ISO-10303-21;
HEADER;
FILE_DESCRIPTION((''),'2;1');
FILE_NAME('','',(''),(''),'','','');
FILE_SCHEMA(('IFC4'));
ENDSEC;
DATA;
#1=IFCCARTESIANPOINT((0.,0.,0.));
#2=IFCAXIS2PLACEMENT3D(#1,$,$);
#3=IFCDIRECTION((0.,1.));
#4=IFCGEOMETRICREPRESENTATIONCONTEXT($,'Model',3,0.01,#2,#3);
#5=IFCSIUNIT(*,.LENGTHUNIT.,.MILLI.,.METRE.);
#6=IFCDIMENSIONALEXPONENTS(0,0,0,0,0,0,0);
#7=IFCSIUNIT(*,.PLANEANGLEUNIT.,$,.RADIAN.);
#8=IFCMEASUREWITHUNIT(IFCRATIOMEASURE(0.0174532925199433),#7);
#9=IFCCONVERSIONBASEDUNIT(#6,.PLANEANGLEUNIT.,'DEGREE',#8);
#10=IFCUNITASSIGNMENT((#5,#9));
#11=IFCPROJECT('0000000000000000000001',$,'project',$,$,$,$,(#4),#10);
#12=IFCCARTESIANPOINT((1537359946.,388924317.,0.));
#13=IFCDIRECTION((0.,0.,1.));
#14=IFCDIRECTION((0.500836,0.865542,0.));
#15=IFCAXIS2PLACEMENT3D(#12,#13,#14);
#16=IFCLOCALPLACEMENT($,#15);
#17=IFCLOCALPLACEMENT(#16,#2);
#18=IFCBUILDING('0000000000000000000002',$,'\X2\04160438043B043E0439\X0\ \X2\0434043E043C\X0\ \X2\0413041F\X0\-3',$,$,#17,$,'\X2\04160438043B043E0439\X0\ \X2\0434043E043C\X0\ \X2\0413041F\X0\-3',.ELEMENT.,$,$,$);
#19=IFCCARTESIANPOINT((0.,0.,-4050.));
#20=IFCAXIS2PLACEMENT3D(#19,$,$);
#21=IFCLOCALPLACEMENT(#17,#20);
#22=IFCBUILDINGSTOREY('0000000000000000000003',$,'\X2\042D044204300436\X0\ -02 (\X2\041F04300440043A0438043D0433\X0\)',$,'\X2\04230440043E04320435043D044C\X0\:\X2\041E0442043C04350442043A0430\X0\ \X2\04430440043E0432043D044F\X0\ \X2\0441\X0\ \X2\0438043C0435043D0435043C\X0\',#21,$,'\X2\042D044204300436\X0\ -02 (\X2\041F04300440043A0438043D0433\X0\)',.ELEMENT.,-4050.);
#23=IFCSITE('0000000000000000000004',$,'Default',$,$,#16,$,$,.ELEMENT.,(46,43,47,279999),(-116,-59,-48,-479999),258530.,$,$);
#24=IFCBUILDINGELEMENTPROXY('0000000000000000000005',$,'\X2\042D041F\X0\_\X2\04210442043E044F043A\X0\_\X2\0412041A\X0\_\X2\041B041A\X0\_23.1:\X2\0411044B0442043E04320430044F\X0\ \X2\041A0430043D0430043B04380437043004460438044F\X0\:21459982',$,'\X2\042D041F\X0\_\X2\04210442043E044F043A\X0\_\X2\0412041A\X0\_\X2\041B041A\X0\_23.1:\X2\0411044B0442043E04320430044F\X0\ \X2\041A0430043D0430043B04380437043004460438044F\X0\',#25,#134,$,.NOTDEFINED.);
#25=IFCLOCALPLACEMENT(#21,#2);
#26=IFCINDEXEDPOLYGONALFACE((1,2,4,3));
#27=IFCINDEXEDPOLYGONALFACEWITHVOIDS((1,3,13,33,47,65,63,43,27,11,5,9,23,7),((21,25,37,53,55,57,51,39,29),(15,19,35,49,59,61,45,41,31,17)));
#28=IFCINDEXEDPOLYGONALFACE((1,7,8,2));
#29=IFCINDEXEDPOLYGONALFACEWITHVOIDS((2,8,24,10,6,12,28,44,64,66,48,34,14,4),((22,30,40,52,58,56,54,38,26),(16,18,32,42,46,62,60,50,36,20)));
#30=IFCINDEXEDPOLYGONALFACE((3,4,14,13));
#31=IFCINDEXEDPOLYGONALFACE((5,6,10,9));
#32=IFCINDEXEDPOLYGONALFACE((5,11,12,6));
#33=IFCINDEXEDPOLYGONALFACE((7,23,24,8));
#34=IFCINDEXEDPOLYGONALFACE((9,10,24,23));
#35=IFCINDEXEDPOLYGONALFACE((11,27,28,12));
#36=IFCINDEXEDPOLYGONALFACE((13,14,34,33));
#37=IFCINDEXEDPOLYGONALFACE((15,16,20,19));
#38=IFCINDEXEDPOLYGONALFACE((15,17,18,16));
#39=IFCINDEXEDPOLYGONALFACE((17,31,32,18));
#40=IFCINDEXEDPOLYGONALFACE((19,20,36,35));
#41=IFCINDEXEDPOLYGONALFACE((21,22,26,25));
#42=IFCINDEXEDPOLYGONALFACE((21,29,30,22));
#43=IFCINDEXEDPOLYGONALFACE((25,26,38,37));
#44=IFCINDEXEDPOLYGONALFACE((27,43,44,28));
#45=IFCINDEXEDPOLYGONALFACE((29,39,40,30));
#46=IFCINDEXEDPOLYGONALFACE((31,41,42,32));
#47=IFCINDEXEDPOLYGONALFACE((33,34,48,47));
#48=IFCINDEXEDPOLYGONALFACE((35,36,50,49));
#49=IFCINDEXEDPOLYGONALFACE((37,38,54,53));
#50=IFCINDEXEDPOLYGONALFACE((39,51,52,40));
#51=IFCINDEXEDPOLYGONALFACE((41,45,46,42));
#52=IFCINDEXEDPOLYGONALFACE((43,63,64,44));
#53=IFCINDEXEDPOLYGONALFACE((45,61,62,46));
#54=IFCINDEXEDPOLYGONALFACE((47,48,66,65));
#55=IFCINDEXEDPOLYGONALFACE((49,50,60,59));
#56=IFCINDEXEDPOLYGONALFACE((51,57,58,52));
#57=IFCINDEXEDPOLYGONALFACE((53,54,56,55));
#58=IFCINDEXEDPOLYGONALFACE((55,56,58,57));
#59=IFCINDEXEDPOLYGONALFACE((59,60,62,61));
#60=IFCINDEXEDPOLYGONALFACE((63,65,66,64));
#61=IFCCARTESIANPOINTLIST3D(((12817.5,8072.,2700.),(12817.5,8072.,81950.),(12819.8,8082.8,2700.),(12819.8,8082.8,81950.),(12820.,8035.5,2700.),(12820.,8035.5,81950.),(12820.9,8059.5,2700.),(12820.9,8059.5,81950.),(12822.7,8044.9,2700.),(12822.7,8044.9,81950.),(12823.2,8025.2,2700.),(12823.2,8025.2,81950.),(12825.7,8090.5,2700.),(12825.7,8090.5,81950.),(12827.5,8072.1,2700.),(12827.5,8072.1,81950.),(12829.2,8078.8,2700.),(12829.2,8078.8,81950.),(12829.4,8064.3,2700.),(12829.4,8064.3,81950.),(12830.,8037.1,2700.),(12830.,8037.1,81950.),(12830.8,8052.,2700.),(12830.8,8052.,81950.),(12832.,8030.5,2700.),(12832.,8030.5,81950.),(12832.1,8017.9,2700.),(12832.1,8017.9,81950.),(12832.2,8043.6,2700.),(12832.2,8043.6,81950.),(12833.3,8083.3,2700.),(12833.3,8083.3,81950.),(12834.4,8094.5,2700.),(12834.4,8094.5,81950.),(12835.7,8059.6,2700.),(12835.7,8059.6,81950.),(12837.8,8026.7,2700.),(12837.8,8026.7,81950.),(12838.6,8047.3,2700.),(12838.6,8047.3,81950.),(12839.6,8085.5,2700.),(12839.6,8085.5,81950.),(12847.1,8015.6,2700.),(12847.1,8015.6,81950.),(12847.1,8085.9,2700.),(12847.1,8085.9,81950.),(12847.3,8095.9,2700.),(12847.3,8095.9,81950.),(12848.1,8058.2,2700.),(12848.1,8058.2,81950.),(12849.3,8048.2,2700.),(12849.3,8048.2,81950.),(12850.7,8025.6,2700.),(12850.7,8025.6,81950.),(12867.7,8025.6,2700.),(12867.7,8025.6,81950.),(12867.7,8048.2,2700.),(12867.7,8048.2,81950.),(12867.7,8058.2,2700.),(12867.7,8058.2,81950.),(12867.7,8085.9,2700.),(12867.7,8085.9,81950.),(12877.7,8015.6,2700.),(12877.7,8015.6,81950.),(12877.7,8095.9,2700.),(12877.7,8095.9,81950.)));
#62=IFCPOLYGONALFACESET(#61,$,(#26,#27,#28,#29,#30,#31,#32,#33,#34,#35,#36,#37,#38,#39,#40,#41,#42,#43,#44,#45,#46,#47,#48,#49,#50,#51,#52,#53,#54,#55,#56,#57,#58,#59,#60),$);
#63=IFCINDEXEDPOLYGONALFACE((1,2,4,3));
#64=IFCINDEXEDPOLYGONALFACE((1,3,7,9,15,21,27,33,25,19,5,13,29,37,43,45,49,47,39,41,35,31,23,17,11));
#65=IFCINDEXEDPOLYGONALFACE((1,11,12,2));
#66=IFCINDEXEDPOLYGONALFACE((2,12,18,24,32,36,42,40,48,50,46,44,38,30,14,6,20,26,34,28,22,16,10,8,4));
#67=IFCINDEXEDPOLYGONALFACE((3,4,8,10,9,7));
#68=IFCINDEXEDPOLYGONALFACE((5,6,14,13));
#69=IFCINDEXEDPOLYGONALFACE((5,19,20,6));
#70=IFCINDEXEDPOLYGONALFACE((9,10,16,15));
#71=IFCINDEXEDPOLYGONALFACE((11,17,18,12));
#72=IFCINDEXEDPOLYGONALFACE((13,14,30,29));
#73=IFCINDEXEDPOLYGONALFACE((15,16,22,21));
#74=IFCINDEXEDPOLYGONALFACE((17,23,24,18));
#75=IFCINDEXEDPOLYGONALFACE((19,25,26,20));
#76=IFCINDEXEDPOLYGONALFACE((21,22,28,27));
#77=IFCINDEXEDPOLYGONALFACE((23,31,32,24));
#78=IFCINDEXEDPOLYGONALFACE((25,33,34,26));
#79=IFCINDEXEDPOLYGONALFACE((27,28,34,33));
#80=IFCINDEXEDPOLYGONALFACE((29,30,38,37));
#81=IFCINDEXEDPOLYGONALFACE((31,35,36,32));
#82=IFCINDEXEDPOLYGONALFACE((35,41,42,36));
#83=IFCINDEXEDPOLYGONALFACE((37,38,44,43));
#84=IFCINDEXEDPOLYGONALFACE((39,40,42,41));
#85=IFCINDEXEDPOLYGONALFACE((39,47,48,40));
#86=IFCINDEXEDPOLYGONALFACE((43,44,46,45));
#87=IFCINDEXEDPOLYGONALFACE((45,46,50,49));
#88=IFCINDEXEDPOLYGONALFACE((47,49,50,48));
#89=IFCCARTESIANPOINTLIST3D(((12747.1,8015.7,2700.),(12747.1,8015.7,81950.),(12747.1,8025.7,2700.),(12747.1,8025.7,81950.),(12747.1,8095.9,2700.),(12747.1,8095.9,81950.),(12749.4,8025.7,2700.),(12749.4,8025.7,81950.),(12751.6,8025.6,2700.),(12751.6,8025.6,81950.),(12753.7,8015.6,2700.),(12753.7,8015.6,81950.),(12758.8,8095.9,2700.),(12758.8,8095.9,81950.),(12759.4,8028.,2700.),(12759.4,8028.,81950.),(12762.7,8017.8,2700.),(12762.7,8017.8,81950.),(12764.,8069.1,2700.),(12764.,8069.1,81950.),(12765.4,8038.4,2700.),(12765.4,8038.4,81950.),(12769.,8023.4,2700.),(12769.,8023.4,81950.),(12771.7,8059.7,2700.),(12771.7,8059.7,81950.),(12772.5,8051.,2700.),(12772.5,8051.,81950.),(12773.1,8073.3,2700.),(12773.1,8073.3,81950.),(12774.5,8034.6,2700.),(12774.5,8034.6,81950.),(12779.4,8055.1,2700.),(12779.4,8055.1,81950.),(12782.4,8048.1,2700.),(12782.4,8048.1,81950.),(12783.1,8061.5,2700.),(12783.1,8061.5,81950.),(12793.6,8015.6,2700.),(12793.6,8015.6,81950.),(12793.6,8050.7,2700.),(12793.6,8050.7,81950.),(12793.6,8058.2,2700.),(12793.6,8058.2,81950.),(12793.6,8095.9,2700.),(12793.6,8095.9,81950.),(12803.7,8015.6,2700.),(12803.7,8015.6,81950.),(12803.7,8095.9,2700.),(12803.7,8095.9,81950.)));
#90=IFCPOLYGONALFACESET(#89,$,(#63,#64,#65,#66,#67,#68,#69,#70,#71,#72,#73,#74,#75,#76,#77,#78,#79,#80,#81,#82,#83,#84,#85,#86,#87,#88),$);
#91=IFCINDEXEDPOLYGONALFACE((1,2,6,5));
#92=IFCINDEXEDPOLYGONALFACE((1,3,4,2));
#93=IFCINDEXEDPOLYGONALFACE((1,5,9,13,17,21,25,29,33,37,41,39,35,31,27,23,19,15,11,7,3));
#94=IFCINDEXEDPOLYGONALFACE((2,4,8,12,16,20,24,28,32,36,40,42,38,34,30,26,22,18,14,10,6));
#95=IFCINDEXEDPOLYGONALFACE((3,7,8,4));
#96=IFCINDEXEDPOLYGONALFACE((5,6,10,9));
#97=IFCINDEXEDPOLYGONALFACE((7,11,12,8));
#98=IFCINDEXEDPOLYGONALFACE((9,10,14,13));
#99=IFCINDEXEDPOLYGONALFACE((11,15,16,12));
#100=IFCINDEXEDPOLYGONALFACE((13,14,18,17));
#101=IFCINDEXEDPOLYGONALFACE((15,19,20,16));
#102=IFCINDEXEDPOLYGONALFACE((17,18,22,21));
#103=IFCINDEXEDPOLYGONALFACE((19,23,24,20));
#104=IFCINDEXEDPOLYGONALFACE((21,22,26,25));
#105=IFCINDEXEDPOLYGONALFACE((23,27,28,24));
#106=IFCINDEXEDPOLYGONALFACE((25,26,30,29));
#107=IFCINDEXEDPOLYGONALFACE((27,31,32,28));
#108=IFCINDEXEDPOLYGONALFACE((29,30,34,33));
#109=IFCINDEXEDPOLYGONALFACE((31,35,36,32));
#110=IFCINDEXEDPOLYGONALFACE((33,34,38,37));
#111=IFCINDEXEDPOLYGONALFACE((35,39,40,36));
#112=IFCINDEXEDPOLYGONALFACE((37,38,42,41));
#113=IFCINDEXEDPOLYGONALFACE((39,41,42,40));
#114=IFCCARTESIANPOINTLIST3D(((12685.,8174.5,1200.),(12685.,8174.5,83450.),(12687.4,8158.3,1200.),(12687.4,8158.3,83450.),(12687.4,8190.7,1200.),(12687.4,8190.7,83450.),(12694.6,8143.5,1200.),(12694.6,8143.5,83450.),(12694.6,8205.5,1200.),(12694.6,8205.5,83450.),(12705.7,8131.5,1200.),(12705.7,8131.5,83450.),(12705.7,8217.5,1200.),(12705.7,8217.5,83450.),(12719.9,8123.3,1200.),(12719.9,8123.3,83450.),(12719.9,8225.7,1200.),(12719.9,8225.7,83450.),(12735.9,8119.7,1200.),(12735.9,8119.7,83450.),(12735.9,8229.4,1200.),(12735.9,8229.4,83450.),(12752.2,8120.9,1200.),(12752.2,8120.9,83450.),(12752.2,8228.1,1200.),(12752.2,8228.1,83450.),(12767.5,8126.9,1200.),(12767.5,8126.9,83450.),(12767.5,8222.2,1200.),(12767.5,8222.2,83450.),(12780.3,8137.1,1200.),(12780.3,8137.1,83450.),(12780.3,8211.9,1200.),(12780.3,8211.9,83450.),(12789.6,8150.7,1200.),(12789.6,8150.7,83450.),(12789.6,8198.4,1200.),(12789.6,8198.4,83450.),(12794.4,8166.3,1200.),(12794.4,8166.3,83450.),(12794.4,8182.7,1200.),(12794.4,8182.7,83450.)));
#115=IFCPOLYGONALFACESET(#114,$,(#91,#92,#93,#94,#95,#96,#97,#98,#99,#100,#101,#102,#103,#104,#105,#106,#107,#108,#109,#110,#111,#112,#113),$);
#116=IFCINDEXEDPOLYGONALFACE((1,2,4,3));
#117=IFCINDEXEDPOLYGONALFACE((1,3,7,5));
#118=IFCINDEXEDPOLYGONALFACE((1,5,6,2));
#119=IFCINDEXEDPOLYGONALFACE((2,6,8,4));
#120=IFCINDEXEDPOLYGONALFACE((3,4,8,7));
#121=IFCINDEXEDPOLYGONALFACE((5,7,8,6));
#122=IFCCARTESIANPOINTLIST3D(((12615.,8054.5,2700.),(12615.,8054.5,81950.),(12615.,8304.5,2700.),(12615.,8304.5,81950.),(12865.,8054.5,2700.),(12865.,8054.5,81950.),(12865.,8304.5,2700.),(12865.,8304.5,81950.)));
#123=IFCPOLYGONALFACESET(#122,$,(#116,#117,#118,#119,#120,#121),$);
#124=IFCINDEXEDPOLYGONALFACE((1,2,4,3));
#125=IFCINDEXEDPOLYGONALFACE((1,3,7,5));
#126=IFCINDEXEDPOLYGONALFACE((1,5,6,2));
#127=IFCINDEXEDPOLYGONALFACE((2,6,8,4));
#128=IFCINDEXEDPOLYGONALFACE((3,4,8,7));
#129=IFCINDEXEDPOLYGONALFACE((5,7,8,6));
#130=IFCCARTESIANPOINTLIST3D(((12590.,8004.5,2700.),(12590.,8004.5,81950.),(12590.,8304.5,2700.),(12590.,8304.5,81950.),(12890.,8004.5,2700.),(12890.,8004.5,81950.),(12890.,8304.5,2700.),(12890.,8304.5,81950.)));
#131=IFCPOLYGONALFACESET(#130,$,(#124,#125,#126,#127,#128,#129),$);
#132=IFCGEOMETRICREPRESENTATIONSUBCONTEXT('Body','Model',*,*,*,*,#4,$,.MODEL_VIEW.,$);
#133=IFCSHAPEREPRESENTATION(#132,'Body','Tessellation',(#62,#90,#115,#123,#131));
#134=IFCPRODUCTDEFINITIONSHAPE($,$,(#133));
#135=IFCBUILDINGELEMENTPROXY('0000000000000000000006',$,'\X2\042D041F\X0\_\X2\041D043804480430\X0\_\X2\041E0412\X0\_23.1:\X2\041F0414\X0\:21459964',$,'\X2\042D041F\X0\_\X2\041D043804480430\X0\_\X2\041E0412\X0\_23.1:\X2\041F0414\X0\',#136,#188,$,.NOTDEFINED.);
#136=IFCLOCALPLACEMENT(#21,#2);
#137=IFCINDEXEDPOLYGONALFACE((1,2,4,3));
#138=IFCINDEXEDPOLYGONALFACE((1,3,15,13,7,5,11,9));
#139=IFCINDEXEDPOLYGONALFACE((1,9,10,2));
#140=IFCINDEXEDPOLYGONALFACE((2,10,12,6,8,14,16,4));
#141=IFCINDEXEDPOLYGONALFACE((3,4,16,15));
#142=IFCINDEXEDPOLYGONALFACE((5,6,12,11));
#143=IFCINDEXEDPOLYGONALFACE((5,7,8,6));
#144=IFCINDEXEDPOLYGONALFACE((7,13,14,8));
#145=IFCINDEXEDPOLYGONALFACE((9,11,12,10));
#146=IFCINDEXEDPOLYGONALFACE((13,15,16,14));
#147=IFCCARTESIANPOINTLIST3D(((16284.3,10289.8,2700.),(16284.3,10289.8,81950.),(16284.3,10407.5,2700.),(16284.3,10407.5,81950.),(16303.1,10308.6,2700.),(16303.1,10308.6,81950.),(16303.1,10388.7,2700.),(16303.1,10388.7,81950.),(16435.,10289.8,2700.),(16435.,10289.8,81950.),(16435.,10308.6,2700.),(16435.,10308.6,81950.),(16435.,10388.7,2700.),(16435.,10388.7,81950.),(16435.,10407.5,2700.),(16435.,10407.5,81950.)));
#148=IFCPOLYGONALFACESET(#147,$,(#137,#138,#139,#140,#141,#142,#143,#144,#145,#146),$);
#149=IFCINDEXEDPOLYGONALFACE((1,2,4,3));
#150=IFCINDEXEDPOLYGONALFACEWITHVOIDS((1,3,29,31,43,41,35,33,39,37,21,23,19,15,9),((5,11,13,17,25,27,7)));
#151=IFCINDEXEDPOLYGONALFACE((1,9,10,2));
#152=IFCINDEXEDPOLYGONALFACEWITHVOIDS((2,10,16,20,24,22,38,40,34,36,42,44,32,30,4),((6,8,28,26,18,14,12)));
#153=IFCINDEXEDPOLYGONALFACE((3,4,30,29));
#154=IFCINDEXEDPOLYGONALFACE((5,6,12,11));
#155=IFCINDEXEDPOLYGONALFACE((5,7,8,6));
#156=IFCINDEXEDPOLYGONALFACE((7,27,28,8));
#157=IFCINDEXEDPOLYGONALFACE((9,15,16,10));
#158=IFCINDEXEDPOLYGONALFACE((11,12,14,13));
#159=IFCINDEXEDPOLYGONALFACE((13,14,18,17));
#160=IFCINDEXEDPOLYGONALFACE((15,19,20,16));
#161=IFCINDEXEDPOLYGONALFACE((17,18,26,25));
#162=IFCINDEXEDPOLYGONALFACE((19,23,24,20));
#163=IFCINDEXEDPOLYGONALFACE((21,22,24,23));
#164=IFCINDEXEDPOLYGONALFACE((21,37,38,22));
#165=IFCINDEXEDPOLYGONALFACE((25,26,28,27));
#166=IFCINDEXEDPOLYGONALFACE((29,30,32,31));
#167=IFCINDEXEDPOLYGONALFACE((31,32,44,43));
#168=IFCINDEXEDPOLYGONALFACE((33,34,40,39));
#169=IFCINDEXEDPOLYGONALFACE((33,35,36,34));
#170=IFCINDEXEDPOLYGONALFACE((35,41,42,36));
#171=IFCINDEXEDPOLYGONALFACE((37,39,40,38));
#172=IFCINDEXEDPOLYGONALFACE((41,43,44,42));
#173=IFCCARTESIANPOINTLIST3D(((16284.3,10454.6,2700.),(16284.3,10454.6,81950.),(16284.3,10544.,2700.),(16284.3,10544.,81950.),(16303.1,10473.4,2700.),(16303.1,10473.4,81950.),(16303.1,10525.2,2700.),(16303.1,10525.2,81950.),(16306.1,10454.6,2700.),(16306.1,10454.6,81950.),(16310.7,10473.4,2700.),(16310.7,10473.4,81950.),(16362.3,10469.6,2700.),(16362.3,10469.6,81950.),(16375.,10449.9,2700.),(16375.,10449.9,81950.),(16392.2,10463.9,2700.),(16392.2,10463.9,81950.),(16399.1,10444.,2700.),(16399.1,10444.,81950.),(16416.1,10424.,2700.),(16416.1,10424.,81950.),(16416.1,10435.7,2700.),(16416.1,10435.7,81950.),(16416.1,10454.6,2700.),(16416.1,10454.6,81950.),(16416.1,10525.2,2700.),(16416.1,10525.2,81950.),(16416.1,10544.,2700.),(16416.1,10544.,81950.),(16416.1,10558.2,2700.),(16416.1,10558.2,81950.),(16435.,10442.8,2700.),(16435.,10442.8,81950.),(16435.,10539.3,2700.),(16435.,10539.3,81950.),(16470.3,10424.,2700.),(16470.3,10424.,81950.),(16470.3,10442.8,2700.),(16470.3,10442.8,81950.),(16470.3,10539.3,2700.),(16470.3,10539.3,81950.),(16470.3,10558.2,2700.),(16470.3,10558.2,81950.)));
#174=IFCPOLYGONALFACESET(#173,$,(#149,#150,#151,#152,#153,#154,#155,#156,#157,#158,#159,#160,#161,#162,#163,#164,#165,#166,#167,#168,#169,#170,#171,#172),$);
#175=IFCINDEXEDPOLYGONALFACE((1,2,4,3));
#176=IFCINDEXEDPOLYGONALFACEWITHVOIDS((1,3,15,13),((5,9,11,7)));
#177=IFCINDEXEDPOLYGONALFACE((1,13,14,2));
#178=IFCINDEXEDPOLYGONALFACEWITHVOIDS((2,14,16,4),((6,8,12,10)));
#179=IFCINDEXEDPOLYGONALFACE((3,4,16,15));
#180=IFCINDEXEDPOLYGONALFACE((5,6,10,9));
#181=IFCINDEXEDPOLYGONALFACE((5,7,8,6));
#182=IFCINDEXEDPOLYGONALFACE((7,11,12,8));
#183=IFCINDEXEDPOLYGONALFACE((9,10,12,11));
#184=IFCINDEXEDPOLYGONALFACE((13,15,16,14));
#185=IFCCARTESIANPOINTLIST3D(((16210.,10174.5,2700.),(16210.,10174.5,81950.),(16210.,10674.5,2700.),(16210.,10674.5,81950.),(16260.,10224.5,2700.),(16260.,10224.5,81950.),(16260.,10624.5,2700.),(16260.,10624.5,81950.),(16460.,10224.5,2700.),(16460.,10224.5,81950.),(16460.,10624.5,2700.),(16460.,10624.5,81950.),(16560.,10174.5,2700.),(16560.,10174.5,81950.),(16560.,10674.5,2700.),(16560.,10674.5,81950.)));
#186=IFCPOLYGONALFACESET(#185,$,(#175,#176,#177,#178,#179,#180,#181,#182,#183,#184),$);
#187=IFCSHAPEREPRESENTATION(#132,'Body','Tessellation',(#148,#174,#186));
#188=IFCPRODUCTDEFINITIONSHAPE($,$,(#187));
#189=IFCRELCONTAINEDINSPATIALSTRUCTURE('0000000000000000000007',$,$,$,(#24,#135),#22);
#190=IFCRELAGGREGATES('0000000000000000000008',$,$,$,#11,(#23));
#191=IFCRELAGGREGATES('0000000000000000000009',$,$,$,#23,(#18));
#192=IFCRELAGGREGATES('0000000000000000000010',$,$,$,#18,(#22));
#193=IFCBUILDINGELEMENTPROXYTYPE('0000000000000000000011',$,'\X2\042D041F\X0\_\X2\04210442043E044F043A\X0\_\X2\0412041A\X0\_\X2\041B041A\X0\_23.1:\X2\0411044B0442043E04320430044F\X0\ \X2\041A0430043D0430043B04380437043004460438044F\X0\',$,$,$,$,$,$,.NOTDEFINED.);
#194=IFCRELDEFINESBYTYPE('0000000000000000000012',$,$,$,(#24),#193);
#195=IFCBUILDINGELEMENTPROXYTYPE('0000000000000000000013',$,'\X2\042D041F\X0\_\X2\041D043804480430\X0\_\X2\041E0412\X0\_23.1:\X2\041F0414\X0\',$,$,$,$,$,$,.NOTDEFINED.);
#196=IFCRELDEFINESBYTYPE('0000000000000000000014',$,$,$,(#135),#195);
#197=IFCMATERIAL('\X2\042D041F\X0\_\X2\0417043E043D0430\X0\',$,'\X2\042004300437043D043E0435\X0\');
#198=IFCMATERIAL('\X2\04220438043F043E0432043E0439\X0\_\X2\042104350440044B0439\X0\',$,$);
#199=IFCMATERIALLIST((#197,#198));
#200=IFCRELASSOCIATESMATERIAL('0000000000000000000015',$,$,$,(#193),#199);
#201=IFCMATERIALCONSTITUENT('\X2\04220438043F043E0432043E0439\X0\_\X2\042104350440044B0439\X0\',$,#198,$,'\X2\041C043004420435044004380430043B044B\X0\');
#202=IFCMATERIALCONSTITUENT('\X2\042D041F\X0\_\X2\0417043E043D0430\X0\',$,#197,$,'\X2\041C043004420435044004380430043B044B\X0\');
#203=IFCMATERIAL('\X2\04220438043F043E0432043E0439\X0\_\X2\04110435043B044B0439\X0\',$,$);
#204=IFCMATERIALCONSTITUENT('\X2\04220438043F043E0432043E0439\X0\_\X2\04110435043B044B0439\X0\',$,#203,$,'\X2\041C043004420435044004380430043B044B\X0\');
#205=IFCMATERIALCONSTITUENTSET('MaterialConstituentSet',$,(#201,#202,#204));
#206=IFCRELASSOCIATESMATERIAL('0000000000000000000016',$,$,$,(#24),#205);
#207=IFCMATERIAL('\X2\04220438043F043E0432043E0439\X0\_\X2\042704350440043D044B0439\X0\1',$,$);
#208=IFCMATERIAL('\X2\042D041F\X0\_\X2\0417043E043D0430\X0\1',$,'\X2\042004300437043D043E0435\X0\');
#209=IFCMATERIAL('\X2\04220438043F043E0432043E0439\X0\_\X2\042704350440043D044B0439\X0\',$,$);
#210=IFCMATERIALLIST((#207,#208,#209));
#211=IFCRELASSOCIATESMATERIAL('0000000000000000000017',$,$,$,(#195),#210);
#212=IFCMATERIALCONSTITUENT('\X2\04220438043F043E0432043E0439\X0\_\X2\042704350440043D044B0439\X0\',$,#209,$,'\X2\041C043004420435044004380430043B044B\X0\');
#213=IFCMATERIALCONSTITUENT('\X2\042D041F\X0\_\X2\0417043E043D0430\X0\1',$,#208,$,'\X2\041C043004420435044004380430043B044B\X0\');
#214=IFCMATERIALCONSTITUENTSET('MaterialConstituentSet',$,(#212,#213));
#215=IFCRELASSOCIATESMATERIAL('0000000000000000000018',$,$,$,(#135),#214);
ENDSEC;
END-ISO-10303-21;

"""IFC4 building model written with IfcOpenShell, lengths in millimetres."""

from ifc_helpers import new_model, entity, si_unit, converted_unit, direction, frame, frame_2d, origin, place, context, subcontext, project, spatial, polyline, rectangle, circle, outline, extrude, source, transform, mapped, material, material_list, constituent, constituent_set, type_object, type_shapes, element, save


model = new_model("IFC4")

# Units and contexts
model_context = context("Model", 3, precision=0.01, world=origin(), true_north=direction((0.0, 1.0)))
body_context = subcontext(model_context, "Body", "Model", "MODEL_VIEW")
ifc_project = project(units=[si_unit("LENGTHUNIT", "METRE", prefix="MILLI"), converted_unit("PLANEANGLEUNIT", "DEGREE", entity("IfcRatioMeasure", 0.0174532925199433), si_unit("PLANEANGLEUNIT", "RADIAN"), dimensions=[0, 0, 0, 0, 0, 0, 0])], contexts=[model_context])

# Site, building, storey
site_placement = place(None, frame((1537359946.0, 388924317.0, 0.0), z_axis=(0.0, 0.0, 1.0), x_axis=(0.500836, 0.865542, 0.0)))
site = spatial("IfcSite", under=ifc_project, at=site_placement, Name="Default", CompositionType="ELEMENT", RefLatitude=(46, 43, 47, 279999), RefLongitude=(-116, -59, -48, -479999), RefElevation=258530.0)
building_placement = place(site_placement, origin())
building = spatial("IfcBuilding", under=site, at=building_placement, Name="Жилой дом ГП-3", LongName="Жилой дом ГП-3", CompositionType="ELEMENT")
storey_placement = place(building_placement, frame((0.0, 0.0, -4050.0)))
storey = spatial("IfcBuildingStorey", under=building, at=storey_placement, Name="Этаж -02 (Паркинг)", ObjectType="Уровень:Отметка уровня с именем", LongName="Этаж -02 (Паркинг)", CompositionType="ELEMENT", Elevation=-4050.0)

# Building element proxies
ifc_material_1 = material(Name="Типовой_Серый")
ifc_material_2 = material(Name="ЭП_Зона", Category="Разное")
ifc_material_3 = material(Name="Типовой_Белый")
ifc_material_list_1 = material_list([ifc_material_2, ifc_material_1])
building_element_proxy_type_1 = type_object("IfcBuildingElementProxyType", Name="ЭП_Стояк_ВК_ЛК_23.1:Бытовая Канализация", PredefinedType="NOTDEFINED", material=ifc_material_list_1)
shared_shape_1 = source(origin(), body_context, "Body", "SweptSolid", [
    extrude(outline(polyline([(-42.2, -39.0), (-11.8, -39.0), (1.1, -37.6), (9.8, -33.5), (15.7, -25.8), (18.0, -15.0), (14.6, -2.5), (4.7, 5.0), (12.8, 12.1), (15.5, 21.5), (12.3, 31.8), (3.4, 39.0), (-11.6, 41.4), (-42.2, 41.4), (-42.2, -39.0)]), holes=[polyline([(-32.2, 8.8), (-32.2, 31.4), (-15.2, 31.4), (-2.3, 30.3), (3.5, 26.4), (5.5, 19.9), (3.3, 13.3), (-3.1, 9.6), (-13.9, 8.8), (-32.2, 8.8)]), polyline([(-32.2, -28.9), (-32.2, -1.3), (-12.6, -1.3), (-0.2, -2.6), (6.1, -7.3), (8.0, -15.1), (6.3, -21.9), (2.2, -26.3), (-4.1, -28.5), (-11.6, -28.9), (-32.2, -28.9)])]), frame((54.5, -52.4, -1350.0)), (0.0, 0.0, 1.0), 79250.0),
    extrude(outline(polyline([(-32.1, -31.9), (48.3, -31.9), (48.3, -21.8), (10.6, -21.8), (13.8, -11.4), (25.6, -1.3), (48.3, 13.0), (48.3, 24.6), (21.4, 7.7), (12.0, 0.1), (7.4, -7.7), (3.3, -0.7), (-9.3, 6.4), (-19.7, 12.3), (-22.1, 20.2), (-22.0, 22.4), (-22.0, 24.6), (-32.0, 24.6), (-32.1, 18.0), (-29.9, 9.0), (-24.3, 2.8), (-13.1, -2.8), (0.4, -10.6), (3.0, -21.8), (-32.1, -21.8), (-32.1, -31.9)])), frame((118.2, -43.1, -1350.0), z_axis=(0.0, 0.0, 1.0), x_axis=(0.0, -1.0, 0.0)), (0.0, 0.0, 1.0), 79250.0),
    extrude(circle(Radius=55.0, at=frame_2d((0.0, 0.0), x_axis=(1.0, 0.0))), frame((150.0, -170.0, -2850.0)), (0.0, 0.0, 1.0), 82250.0),
    extrude(rectangle(XDim=250.0, YDim=250.0, at=frame_2d((0.0, 0.0), x_axis=(1.0, 0.0))), frame((150.0, -175.0, -1350.0)), (0.0, 0.0, 1.0), 79250.0),
    extrude(rectangle(XDim=300.0, YDim=300.0, at=frame_2d((0.0, 0.0), x_axis=(1.0, 0.0))), frame((150.0, -150.0, -1350.0)), (0.0, 0.0, 1.0), 79250.0),
])
type_shapes(building_element_proxy_type_1, [shared_shape_1])
ifc_constituent_1 = constituent(ifc_material_1, Name="Типовой_Серый", Category="Материалы")
ifc_constituent_2 = constituent(ifc_material_2, Name="ЭП_Зона", Category="Материалы")
ifc_constituent_3 = constituent(ifc_material_3, Name="Типовой_Белый", Category="Материалы")
ifc_constituent_set_1 = constituent_set(constituents=[ifc_constituent_1, ifc_constituent_2, ifc_constituent_3], Name="MaterialConstituentSet")
proxy_1_placement = place(storey_placement, frame((12890.0, 8004.5, 4050.0), z_axis=(0.0, 0.0, 1.0), x_axis=(-1.0, 0.0, 0.0)))
element("IfcBuildingElementProxy", 1, at=proxy_1_placement, inside=storey, type_object=building_element_proxy_type_1, material=ifc_constituent_set_1, Name="ЭП_Стояк_ВК_ЛК_23.1:Бытовая Канализация:21459982", ObjectType="ЭП_Стояк_ВК_ЛК_23.1:Бытовая Канализация", PredefinedType="NOTDEFINED", context=body_context, shape_type="MappedRepresentation", body=[
    mapped(shared_shape_1, transform((0.0, 0.0, 0.0), scale=1.0)),
])
ifc_material_4 = material(Name="Типовой_Черный")
ifc_constituent_4 = constituent(ifc_material_4, Name="Типовой_Черный", Category="Материалы")
ifc_material_5 = material(Name="ЭП_Зона1", Category="Разное")
ifc_constituent_5 = constituent(ifc_material_5, Name="ЭП_Зона1", Category="Материалы")
ifc_constituent_set_2 = constituent_set(constituents=[ifc_constituent_4, ifc_constituent_5], Name="MaterialConstituentSet")
ifc_material_6 = material(Name="Типовой_Черный1")
ifc_material_list_2 = material_list([ifc_material_6, ifc_material_5, ifc_material_4])
building_element_proxy_type_2 = type_object("IfcBuildingElementProxyType", Name="ЭП_Ниша_ОВ_23.1:ПД", PredefinedType="NOTDEFINED", material=ifc_material_list_2)
shared_shape_2 = source(origin(), body_context, "Body", "SweptSolid", [
    extrude(outline(polyline([(-80.1, -58.9), (70.6, -58.9), (70.6, -40.0), (-61.2, -40.0), (-61.2, 40.0), (70.6, 40.0), (70.6, 58.9), (-80.1, 58.9), (-80.1, -58.9)])), frame((174.1, 195.6, 0.0), z_axis=(0.0, 0.0, 1.0), x_axis=(0.0, -1.0, 0.0)), (0.0, 0.0, 1.0), 79250.0),
    extrude(outline(polyline([(-120.0, 29.1), (-120.0, -60.4), (11.8, -60.4), (11.8, -74.5), (66.0, -74.5), (66.0, -55.6), (30.7, -55.6), (30.7, 40.9), (66.0, 40.9), (66.0, 59.7), (11.8, 59.7), (11.8, 48.0), (-5.2, 39.7), (-29.3, 33.8), (-98.2, 29.1), (-120.0, 29.1)]), holes=[polyline([(-101.2, -41.5), (-101.2, 10.3), (-93.6, 10.3), (-42.0, 14.1), (-12.2, 19.8), (11.8, 29.1), (11.8, -41.5), (-101.2, -41.5)])]), frame((309.2, 155.7, 0.0), z_axis=(0.0, 0.0, -1.0), x_axis=(0.0, -1.0, 0.0)), (0.0, 0.0, -1.0), 79250.0),
    extrude(outline(polyline([(-250.0, -175.0), (250.0, -175.0), (250.0, 175.0), (-250.0, 175.0), (-250.0, -175.0)]), holes=[polyline([(200.0, 125.0), (200.0, -75.0), (-200.0, -75.0), (-200.0, 125.0), (200.0, 125.0)])]), frame((250.0, 175.0, 0.0)), (0.0, 0.0, 1.0), 79250.0),
])
type_shapes(building_element_proxy_type_2, [shared_shape_2])
proxy_2_placement = place(storey_placement, frame((16560.0, 10174.5, 2700.0), z_axis=(0.0, 0.0, 1.0), x_axis=(0.0, 1.0, 0.0)))
element("IfcBuildingElementProxy", 2, at=proxy_2_placement, inside=storey, type_object=building_element_proxy_type_2, material=ifc_constituent_set_2, Name="ЭП_Ниша_ОВ_23.1:ПД:21459964", ObjectType="ЭП_Ниша_ОВ_23.1:ПД", PredefinedType="NOTDEFINED", context=body_context, shape_type="MappedRepresentation", body=[
    mapped(shared_shape_2, transform((0.0, 0.0, 0.0), scale=1.0)),
])

save(model, "model.ifc")
